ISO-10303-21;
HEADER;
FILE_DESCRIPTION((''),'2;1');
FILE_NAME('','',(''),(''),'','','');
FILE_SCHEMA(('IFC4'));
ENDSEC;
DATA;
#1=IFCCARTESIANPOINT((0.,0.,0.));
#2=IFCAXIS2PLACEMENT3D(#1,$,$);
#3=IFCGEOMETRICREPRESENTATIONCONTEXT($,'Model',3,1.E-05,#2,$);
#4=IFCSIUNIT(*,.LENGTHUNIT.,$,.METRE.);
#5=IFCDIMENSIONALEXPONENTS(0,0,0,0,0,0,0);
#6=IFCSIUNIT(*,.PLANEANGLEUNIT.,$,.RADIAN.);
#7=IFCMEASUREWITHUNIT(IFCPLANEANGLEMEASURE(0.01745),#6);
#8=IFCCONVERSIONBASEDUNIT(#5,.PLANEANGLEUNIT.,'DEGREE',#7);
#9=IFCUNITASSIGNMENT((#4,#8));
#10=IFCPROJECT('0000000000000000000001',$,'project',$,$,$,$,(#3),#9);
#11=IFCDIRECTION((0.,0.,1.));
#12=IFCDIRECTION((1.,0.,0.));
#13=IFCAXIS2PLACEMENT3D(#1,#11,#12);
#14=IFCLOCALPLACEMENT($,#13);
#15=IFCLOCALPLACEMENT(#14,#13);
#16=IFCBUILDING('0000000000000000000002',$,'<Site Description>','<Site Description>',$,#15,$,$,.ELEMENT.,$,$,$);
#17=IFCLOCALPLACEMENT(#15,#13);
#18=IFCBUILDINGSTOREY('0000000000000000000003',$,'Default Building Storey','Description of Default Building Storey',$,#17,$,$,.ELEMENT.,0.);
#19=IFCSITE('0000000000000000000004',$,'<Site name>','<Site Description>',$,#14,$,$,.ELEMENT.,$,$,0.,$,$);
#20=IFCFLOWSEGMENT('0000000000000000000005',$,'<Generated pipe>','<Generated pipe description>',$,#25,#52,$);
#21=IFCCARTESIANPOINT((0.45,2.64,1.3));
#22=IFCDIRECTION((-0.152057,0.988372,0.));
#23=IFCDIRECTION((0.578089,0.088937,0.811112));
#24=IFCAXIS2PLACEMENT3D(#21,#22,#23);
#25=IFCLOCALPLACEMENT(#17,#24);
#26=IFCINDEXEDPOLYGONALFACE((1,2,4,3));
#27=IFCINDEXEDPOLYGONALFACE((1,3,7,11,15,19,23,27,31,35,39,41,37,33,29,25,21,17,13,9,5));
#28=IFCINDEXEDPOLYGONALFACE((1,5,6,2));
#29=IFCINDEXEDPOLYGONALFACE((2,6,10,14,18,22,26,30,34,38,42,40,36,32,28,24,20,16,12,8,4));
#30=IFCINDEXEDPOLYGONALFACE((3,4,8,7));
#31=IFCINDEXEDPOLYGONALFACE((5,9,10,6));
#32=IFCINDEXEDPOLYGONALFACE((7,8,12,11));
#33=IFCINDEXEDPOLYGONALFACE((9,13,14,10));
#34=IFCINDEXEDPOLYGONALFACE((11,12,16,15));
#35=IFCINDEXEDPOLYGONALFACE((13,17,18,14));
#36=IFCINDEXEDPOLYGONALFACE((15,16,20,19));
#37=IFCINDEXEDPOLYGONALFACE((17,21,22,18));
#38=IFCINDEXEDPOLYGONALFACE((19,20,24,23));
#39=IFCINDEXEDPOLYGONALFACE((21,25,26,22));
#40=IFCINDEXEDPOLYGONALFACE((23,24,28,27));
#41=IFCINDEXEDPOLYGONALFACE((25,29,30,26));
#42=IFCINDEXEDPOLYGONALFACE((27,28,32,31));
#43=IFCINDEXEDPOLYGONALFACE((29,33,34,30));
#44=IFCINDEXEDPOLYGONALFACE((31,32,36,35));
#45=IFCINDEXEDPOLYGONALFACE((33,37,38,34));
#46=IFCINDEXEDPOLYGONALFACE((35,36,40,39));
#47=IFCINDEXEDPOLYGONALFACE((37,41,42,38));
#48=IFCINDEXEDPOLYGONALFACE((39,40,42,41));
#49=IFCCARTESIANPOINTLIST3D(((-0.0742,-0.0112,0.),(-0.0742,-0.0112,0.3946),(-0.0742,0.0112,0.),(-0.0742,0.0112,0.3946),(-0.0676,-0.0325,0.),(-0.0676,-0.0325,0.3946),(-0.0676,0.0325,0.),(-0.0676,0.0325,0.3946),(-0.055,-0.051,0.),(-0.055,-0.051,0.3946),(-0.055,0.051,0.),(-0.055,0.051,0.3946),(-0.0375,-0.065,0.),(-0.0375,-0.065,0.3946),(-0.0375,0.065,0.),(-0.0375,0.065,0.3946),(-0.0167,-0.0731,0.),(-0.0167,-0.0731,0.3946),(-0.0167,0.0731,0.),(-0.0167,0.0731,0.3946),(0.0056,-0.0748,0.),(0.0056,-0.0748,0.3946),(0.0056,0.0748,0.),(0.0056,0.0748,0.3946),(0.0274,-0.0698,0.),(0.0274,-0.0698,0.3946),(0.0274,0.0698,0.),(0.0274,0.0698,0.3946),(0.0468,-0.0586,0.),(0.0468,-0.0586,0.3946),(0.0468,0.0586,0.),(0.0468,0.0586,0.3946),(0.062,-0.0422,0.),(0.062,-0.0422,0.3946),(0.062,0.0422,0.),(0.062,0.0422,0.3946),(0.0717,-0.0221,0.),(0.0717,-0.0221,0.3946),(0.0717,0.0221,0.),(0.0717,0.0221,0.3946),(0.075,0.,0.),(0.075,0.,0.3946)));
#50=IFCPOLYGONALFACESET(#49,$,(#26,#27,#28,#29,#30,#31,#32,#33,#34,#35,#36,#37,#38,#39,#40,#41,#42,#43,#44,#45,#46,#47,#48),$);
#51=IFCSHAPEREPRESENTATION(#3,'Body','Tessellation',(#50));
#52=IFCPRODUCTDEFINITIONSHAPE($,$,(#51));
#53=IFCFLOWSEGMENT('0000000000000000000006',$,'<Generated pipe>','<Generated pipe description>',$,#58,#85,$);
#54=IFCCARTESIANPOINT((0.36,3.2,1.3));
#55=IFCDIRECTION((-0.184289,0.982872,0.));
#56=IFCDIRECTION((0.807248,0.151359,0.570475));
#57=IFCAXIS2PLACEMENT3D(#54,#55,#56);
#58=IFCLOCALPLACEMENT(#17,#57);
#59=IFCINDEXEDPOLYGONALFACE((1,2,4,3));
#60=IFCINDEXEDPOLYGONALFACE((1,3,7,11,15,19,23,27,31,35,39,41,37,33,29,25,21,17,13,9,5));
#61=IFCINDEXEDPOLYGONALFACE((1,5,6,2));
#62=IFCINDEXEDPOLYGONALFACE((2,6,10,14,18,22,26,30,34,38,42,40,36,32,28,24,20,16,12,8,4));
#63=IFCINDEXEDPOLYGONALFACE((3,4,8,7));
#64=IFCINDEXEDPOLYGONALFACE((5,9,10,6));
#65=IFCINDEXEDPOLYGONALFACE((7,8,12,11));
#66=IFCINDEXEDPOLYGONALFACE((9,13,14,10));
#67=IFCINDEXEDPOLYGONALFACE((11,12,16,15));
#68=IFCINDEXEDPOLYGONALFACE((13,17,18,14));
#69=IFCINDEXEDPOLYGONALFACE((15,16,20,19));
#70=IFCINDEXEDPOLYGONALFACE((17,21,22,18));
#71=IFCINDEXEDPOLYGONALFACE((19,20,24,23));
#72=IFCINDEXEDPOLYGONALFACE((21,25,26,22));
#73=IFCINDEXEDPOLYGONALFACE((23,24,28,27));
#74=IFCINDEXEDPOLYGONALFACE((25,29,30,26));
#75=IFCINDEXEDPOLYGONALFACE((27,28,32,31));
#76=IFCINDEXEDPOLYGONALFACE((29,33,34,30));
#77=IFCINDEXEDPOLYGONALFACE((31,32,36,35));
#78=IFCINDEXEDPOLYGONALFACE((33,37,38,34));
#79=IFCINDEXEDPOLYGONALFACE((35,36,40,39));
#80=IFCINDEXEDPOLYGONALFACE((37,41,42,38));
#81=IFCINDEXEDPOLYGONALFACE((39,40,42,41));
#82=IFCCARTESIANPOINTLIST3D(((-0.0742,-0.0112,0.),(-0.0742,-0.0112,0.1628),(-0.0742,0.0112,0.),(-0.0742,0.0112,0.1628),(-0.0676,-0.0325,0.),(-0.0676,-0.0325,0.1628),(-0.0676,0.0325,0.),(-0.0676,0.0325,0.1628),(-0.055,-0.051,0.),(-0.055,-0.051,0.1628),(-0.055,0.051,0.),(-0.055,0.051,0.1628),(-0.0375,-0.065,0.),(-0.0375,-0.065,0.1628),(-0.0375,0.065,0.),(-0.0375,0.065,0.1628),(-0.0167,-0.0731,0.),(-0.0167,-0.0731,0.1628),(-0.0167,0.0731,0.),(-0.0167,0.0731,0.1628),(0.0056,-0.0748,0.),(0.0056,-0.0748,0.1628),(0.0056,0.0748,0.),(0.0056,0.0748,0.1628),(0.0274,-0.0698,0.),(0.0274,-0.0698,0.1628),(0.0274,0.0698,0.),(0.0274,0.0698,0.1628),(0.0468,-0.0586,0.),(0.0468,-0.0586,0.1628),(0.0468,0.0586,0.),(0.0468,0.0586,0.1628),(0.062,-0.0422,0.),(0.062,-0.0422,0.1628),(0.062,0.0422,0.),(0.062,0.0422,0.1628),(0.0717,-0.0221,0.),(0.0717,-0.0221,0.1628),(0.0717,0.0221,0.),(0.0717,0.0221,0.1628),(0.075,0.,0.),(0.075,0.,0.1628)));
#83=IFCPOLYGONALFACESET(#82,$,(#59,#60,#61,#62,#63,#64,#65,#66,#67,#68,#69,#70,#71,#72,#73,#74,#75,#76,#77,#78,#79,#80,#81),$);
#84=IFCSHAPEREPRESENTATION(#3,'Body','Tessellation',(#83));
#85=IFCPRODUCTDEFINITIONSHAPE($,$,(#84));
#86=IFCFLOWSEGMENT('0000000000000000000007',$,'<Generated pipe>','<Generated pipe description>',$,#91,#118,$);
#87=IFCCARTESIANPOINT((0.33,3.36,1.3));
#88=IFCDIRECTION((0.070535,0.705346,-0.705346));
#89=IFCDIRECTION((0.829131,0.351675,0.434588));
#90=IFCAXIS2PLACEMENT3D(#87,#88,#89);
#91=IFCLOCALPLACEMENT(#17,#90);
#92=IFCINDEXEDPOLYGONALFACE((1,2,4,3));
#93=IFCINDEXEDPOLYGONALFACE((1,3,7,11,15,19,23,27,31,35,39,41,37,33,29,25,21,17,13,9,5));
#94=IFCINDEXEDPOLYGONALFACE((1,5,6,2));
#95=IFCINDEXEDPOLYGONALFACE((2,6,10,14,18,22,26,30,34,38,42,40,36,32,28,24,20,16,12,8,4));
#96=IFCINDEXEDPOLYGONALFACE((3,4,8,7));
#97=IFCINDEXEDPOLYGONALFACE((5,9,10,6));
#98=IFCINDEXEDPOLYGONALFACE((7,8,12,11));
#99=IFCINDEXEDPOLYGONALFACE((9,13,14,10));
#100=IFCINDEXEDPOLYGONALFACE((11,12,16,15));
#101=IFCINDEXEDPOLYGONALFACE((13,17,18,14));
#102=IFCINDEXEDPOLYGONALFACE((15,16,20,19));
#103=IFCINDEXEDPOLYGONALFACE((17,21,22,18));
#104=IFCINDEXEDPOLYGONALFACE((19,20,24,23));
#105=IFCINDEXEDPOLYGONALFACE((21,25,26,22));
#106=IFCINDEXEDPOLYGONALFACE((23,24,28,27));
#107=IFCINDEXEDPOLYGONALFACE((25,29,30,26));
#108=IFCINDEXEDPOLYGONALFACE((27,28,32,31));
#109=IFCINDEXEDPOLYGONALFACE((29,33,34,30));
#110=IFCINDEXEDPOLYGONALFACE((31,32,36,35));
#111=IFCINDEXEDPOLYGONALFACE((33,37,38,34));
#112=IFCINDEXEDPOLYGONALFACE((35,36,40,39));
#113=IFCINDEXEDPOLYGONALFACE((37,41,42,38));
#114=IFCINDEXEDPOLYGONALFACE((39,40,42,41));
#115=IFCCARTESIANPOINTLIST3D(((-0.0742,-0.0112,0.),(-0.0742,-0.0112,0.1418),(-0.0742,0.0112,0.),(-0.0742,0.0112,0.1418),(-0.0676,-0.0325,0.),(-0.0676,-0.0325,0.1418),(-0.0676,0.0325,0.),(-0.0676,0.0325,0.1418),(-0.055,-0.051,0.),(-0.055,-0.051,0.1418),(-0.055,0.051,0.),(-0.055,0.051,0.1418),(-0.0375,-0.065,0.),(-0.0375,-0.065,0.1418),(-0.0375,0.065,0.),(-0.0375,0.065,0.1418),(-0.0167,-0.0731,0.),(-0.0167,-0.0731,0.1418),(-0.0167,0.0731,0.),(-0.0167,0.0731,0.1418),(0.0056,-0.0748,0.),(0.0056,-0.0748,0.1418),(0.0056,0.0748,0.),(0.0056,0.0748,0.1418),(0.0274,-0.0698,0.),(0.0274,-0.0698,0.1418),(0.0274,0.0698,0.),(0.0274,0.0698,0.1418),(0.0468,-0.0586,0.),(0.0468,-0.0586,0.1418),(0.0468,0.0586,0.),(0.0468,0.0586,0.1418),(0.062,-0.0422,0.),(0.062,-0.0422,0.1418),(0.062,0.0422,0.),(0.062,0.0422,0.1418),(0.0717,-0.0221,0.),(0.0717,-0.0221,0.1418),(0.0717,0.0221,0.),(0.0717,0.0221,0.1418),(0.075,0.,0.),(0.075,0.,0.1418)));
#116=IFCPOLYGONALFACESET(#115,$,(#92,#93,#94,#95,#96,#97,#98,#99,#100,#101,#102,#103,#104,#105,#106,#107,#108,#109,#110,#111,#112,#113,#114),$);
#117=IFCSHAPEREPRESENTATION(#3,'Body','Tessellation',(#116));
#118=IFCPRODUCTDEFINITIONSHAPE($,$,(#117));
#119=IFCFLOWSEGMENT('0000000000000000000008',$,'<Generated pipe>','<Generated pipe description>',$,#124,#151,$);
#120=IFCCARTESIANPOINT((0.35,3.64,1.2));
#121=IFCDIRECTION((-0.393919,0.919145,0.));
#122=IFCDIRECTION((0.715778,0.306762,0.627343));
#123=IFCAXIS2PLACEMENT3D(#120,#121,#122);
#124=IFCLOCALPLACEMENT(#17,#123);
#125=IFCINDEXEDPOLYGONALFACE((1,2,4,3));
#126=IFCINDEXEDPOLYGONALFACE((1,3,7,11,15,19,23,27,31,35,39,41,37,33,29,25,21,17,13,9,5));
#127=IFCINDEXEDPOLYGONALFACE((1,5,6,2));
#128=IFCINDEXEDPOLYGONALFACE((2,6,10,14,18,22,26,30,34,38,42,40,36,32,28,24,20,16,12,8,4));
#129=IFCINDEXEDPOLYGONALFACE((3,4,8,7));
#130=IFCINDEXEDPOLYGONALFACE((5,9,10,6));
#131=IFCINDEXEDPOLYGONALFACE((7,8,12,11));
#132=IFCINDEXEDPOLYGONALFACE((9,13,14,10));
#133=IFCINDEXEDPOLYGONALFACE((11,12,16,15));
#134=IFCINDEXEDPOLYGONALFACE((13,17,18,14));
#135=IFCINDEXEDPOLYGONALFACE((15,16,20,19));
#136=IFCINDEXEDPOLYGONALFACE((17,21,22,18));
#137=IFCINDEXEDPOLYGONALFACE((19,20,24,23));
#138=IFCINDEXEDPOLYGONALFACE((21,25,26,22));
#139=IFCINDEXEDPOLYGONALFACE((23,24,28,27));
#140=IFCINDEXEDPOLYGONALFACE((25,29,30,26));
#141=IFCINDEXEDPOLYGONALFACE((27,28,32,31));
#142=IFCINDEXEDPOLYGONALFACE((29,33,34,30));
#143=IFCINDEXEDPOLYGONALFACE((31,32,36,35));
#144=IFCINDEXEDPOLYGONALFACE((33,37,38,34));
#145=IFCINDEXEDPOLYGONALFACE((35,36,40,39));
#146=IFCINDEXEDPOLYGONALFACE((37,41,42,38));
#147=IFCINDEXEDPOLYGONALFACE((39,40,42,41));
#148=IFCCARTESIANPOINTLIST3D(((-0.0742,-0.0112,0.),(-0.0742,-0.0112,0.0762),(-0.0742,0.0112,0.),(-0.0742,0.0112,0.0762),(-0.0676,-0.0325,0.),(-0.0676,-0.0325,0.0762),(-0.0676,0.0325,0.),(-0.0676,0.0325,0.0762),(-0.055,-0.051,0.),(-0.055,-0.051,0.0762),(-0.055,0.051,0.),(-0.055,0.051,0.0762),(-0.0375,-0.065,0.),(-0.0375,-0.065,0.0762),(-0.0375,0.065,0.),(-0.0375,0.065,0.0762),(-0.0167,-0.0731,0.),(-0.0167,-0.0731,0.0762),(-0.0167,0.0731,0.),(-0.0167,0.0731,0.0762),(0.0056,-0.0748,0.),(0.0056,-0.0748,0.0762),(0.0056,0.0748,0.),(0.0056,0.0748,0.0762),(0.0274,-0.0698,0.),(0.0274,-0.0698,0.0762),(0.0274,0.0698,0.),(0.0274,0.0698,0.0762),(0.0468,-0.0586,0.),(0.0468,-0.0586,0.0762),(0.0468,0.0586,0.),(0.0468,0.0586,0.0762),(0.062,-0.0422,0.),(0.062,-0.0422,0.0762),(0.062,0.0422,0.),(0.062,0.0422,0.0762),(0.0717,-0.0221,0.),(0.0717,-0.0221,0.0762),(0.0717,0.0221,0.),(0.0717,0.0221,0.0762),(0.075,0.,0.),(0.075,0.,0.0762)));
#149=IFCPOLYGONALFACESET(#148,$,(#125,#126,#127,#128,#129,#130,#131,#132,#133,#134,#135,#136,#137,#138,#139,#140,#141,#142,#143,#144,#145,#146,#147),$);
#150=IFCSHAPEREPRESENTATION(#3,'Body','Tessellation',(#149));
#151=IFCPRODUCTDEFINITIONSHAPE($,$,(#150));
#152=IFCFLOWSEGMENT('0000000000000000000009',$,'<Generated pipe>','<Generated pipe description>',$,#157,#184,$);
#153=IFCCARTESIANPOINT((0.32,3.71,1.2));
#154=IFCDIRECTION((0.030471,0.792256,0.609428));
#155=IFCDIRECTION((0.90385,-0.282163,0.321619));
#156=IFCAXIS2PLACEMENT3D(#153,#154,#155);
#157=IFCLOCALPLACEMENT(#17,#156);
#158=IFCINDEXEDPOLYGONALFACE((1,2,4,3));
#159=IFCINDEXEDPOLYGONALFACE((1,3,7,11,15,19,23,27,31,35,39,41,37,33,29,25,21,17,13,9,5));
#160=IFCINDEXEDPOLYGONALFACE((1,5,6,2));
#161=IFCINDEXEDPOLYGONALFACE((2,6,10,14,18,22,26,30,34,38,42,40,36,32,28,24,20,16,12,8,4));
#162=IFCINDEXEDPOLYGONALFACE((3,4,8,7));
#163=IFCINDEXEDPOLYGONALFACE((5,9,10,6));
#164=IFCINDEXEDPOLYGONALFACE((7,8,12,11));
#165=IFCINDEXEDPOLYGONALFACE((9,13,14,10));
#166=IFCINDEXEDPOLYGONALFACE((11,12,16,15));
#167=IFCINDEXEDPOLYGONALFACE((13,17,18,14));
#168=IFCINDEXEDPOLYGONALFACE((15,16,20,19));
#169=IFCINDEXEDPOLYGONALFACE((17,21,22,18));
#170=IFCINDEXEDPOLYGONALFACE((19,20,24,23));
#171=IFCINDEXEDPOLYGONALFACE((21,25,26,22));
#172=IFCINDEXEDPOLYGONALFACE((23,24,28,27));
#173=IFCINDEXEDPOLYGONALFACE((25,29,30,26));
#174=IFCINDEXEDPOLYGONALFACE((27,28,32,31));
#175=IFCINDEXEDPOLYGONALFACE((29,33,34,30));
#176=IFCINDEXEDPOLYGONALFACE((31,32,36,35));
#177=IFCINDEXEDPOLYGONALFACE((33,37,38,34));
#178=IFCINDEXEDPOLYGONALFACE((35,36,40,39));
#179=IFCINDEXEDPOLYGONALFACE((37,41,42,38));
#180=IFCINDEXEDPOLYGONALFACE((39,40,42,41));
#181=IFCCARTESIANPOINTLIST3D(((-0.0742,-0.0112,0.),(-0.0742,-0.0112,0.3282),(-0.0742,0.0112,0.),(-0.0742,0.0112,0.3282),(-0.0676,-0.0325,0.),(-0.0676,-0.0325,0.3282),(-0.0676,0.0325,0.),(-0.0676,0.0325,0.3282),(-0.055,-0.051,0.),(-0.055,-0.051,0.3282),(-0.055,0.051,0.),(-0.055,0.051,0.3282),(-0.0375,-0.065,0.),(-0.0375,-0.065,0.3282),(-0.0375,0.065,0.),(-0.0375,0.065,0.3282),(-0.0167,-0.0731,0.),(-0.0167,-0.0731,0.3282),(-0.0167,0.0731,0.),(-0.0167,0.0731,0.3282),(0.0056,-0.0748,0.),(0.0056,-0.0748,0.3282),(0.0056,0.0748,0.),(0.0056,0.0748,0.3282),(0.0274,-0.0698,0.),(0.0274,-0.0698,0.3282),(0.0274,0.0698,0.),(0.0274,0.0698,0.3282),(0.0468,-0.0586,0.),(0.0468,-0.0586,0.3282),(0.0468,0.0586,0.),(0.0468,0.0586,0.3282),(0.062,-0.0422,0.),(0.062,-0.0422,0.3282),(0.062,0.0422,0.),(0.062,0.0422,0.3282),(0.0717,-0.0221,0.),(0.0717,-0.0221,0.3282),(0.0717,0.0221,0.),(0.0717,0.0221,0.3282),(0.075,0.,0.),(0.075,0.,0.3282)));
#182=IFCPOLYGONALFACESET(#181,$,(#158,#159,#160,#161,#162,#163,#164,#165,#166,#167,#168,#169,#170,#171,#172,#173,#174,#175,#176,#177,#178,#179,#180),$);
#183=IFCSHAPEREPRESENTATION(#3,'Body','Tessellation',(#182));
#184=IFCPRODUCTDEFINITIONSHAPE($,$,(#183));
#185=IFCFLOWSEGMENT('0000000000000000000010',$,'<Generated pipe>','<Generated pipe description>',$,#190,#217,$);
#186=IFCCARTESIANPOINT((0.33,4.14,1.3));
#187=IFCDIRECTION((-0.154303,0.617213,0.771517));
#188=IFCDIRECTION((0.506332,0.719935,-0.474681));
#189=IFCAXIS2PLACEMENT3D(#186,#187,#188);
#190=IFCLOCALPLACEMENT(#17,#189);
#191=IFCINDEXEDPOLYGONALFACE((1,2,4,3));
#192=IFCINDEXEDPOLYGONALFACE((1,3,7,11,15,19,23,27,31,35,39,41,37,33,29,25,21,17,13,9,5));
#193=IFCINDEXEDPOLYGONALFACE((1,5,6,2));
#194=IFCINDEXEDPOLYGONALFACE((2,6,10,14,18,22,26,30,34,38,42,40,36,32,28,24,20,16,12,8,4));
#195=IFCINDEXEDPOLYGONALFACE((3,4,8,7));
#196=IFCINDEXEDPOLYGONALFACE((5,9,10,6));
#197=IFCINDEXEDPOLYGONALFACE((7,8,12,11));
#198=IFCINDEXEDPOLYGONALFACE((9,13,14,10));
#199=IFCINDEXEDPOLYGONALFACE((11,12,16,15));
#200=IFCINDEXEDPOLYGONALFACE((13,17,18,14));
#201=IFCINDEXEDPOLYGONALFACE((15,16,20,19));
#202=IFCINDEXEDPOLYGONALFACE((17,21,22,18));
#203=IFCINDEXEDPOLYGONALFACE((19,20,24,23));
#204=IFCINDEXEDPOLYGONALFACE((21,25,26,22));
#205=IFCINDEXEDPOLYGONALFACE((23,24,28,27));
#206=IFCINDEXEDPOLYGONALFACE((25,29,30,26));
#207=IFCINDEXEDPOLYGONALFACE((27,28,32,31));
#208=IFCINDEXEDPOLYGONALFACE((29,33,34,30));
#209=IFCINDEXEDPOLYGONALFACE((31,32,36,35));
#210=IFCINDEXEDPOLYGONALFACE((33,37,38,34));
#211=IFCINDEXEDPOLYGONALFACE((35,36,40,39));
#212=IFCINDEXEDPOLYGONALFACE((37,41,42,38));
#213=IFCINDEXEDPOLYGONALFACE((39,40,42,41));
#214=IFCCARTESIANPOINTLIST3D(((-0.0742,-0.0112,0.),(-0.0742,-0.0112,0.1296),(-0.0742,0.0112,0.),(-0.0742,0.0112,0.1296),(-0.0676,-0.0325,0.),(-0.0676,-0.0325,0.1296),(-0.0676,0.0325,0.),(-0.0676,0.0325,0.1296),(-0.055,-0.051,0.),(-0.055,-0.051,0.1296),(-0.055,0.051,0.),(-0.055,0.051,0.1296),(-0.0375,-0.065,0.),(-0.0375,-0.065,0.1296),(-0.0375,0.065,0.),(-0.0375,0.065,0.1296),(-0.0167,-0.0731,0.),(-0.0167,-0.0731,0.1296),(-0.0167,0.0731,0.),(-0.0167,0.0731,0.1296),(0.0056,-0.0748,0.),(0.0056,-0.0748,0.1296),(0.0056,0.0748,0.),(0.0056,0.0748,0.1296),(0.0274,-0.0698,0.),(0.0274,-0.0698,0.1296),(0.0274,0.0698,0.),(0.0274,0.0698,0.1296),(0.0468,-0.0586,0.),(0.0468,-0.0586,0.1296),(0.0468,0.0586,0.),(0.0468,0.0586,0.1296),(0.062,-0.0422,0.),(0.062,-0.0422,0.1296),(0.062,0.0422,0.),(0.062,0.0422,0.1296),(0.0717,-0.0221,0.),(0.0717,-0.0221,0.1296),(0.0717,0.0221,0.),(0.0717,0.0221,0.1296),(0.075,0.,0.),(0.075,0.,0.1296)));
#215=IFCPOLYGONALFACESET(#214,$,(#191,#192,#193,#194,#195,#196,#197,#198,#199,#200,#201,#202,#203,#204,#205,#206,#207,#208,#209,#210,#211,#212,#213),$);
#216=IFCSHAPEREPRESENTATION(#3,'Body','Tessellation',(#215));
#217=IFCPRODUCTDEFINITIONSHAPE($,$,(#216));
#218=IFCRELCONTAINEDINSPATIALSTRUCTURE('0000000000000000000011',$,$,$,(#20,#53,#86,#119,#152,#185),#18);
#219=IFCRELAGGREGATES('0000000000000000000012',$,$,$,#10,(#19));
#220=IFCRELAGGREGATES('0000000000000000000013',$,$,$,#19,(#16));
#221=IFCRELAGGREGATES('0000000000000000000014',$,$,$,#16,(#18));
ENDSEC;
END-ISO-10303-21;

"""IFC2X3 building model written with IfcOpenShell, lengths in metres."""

from ifc_helpers import new_model, entity, si_unit, converted_unit, frame, origin, origin_with_axes, origin_2d_with_axis, place, context, project, spatial, circle, extrude, element, save


model = new_model("IFC2X3")

# Units and contexts
model_context = context("Model", 3, precision=1e-05, world=origin())
ifc_project = project(units=[si_unit("LENGTHUNIT", "METRE"), converted_unit("PLANEANGLEUNIT", "DEGREE", entity("IfcPlaneAngleMeasure", 0.01745), si_unit("PLANEANGLEUNIT", "RADIAN"), dimensions=[0, 0, 0, 0, 0, 0, 0])], contexts=[model_context])

# Site, building, storey
site_placement = place(None, origin_with_axes())
site = spatial("IfcSite", under=ifc_project, at=site_placement, Name="<Site name>", Description="<Site Description>", CompositionType="ELEMENT", RefElevation=0.0)
building_placement = place(site_placement, origin_with_axes())
building = spatial("IfcBuilding", under=site, at=building_placement, Name="<Site Description>", Description="<Site Description>", CompositionType="ELEMENT")
storey_placement = place(building_placement, origin_with_axes())
storey = spatial("IfcBuildingStorey", under=building, at=storey_placement, Name="Default Building Storey", Description="Description of Default Building Storey", CompositionType="ELEMENT", Elevation=0.0)

# Flow segments
flow_segment_1_placement = place(storey_placement, frame((0.45, 2.64, 1.3), z_axis=(-0.152057, 0.988372, 0.0), x_axis=(0.578089, 0.088937, 0.811112)))
element("IfcFlowSegment", 1, at=flow_segment_1_placement, inside=storey, Name="<Generated pipe>", Description="<Generated pipe description>", context=model_context, shape_type="SweptSolid", body=[
    extrude(circle(Radius=0.075, at=origin_2d_with_axis()), origin_with_axes(), (0.0, 0.0, 1.0), 0.3946),
])
flow_segment_2_placement = place(storey_placement, frame((0.36, 3.2, 1.3), z_axis=(-0.184289, 0.982872, 0.0), x_axis=(0.807248, 0.151359, 0.570475)))
element("IfcFlowSegment", 2, at=flow_segment_2_placement, inside=storey, Name="<Generated pipe>", Description="<Generated pipe description>", context=model_context, shape_type="SweptSolid", body=[
    extrude(circle(Radius=0.075, at=origin_2d_with_axis()), origin_with_axes(), (0.0, 0.0, 1.0), 0.1628),
])
flow_segment_3_placement = place(storey_placement, frame((0.33, 3.36, 1.3), z_axis=(0.070535, 0.705346, -0.705346), x_axis=(0.829131, 0.351675, 0.434588)))
element("IfcFlowSegment", 3, at=flow_segment_3_placement, inside=storey, Name="<Generated pipe>", Description="<Generated pipe description>", context=model_context, shape_type="SweptSolid", body=[
    extrude(circle(Radius=0.075, at=origin_2d_with_axis()), origin_with_axes(), (0.0, 0.0, 1.0), 0.1418),
])
flow_segment_4_placement = place(storey_placement, frame((0.35, 3.64, 1.2), z_axis=(-0.393919, 0.919145, 0.0), x_axis=(0.715778, 0.306762, 0.627343)))
element("IfcFlowSegment", 4, at=flow_segment_4_placement, inside=storey, Name="<Generated pipe>", Description="<Generated pipe description>", context=model_context, shape_type="SweptSolid", body=[
    extrude(circle(Radius=0.075, at=origin_2d_with_axis()), origin_with_axes(), (0.0, 0.0, 1.0), 0.0762),
])
flow_segment_5_placement = place(storey_placement, frame((0.32, 3.71, 1.2), z_axis=(0.030471, 0.792256, 0.609428), x_axis=(0.90385, -0.282163, 0.321619)))
element("IfcFlowSegment", 5, at=flow_segment_5_placement, inside=storey, Name="<Generated pipe>", Description="<Generated pipe description>", context=model_context, shape_type="SweptSolid", body=[
    extrude(circle(Radius=0.075, at=origin_2d_with_axis()), origin_with_axes(), (0.0, 0.0, 1.0), 0.3282),
])
flow_segment_6_placement = place(storey_placement, frame((0.33, 4.14, 1.3), z_axis=(-0.154303, 0.617213, 0.771517), x_axis=(0.506332, 0.719935, -0.474681)))
element("IfcFlowSegment", 6, at=flow_segment_6_placement, inside=storey, Name="<Generated pipe>", Description="<Generated pipe description>", context=model_context, shape_type="SweptSolid", body=[
    extrude(circle(Radius=0.075, at=origin_2d_with_axis()), origin_with_axes(), (0.0, 0.0, 1.0), 0.1296),
])

save(model, "model.ifc")
